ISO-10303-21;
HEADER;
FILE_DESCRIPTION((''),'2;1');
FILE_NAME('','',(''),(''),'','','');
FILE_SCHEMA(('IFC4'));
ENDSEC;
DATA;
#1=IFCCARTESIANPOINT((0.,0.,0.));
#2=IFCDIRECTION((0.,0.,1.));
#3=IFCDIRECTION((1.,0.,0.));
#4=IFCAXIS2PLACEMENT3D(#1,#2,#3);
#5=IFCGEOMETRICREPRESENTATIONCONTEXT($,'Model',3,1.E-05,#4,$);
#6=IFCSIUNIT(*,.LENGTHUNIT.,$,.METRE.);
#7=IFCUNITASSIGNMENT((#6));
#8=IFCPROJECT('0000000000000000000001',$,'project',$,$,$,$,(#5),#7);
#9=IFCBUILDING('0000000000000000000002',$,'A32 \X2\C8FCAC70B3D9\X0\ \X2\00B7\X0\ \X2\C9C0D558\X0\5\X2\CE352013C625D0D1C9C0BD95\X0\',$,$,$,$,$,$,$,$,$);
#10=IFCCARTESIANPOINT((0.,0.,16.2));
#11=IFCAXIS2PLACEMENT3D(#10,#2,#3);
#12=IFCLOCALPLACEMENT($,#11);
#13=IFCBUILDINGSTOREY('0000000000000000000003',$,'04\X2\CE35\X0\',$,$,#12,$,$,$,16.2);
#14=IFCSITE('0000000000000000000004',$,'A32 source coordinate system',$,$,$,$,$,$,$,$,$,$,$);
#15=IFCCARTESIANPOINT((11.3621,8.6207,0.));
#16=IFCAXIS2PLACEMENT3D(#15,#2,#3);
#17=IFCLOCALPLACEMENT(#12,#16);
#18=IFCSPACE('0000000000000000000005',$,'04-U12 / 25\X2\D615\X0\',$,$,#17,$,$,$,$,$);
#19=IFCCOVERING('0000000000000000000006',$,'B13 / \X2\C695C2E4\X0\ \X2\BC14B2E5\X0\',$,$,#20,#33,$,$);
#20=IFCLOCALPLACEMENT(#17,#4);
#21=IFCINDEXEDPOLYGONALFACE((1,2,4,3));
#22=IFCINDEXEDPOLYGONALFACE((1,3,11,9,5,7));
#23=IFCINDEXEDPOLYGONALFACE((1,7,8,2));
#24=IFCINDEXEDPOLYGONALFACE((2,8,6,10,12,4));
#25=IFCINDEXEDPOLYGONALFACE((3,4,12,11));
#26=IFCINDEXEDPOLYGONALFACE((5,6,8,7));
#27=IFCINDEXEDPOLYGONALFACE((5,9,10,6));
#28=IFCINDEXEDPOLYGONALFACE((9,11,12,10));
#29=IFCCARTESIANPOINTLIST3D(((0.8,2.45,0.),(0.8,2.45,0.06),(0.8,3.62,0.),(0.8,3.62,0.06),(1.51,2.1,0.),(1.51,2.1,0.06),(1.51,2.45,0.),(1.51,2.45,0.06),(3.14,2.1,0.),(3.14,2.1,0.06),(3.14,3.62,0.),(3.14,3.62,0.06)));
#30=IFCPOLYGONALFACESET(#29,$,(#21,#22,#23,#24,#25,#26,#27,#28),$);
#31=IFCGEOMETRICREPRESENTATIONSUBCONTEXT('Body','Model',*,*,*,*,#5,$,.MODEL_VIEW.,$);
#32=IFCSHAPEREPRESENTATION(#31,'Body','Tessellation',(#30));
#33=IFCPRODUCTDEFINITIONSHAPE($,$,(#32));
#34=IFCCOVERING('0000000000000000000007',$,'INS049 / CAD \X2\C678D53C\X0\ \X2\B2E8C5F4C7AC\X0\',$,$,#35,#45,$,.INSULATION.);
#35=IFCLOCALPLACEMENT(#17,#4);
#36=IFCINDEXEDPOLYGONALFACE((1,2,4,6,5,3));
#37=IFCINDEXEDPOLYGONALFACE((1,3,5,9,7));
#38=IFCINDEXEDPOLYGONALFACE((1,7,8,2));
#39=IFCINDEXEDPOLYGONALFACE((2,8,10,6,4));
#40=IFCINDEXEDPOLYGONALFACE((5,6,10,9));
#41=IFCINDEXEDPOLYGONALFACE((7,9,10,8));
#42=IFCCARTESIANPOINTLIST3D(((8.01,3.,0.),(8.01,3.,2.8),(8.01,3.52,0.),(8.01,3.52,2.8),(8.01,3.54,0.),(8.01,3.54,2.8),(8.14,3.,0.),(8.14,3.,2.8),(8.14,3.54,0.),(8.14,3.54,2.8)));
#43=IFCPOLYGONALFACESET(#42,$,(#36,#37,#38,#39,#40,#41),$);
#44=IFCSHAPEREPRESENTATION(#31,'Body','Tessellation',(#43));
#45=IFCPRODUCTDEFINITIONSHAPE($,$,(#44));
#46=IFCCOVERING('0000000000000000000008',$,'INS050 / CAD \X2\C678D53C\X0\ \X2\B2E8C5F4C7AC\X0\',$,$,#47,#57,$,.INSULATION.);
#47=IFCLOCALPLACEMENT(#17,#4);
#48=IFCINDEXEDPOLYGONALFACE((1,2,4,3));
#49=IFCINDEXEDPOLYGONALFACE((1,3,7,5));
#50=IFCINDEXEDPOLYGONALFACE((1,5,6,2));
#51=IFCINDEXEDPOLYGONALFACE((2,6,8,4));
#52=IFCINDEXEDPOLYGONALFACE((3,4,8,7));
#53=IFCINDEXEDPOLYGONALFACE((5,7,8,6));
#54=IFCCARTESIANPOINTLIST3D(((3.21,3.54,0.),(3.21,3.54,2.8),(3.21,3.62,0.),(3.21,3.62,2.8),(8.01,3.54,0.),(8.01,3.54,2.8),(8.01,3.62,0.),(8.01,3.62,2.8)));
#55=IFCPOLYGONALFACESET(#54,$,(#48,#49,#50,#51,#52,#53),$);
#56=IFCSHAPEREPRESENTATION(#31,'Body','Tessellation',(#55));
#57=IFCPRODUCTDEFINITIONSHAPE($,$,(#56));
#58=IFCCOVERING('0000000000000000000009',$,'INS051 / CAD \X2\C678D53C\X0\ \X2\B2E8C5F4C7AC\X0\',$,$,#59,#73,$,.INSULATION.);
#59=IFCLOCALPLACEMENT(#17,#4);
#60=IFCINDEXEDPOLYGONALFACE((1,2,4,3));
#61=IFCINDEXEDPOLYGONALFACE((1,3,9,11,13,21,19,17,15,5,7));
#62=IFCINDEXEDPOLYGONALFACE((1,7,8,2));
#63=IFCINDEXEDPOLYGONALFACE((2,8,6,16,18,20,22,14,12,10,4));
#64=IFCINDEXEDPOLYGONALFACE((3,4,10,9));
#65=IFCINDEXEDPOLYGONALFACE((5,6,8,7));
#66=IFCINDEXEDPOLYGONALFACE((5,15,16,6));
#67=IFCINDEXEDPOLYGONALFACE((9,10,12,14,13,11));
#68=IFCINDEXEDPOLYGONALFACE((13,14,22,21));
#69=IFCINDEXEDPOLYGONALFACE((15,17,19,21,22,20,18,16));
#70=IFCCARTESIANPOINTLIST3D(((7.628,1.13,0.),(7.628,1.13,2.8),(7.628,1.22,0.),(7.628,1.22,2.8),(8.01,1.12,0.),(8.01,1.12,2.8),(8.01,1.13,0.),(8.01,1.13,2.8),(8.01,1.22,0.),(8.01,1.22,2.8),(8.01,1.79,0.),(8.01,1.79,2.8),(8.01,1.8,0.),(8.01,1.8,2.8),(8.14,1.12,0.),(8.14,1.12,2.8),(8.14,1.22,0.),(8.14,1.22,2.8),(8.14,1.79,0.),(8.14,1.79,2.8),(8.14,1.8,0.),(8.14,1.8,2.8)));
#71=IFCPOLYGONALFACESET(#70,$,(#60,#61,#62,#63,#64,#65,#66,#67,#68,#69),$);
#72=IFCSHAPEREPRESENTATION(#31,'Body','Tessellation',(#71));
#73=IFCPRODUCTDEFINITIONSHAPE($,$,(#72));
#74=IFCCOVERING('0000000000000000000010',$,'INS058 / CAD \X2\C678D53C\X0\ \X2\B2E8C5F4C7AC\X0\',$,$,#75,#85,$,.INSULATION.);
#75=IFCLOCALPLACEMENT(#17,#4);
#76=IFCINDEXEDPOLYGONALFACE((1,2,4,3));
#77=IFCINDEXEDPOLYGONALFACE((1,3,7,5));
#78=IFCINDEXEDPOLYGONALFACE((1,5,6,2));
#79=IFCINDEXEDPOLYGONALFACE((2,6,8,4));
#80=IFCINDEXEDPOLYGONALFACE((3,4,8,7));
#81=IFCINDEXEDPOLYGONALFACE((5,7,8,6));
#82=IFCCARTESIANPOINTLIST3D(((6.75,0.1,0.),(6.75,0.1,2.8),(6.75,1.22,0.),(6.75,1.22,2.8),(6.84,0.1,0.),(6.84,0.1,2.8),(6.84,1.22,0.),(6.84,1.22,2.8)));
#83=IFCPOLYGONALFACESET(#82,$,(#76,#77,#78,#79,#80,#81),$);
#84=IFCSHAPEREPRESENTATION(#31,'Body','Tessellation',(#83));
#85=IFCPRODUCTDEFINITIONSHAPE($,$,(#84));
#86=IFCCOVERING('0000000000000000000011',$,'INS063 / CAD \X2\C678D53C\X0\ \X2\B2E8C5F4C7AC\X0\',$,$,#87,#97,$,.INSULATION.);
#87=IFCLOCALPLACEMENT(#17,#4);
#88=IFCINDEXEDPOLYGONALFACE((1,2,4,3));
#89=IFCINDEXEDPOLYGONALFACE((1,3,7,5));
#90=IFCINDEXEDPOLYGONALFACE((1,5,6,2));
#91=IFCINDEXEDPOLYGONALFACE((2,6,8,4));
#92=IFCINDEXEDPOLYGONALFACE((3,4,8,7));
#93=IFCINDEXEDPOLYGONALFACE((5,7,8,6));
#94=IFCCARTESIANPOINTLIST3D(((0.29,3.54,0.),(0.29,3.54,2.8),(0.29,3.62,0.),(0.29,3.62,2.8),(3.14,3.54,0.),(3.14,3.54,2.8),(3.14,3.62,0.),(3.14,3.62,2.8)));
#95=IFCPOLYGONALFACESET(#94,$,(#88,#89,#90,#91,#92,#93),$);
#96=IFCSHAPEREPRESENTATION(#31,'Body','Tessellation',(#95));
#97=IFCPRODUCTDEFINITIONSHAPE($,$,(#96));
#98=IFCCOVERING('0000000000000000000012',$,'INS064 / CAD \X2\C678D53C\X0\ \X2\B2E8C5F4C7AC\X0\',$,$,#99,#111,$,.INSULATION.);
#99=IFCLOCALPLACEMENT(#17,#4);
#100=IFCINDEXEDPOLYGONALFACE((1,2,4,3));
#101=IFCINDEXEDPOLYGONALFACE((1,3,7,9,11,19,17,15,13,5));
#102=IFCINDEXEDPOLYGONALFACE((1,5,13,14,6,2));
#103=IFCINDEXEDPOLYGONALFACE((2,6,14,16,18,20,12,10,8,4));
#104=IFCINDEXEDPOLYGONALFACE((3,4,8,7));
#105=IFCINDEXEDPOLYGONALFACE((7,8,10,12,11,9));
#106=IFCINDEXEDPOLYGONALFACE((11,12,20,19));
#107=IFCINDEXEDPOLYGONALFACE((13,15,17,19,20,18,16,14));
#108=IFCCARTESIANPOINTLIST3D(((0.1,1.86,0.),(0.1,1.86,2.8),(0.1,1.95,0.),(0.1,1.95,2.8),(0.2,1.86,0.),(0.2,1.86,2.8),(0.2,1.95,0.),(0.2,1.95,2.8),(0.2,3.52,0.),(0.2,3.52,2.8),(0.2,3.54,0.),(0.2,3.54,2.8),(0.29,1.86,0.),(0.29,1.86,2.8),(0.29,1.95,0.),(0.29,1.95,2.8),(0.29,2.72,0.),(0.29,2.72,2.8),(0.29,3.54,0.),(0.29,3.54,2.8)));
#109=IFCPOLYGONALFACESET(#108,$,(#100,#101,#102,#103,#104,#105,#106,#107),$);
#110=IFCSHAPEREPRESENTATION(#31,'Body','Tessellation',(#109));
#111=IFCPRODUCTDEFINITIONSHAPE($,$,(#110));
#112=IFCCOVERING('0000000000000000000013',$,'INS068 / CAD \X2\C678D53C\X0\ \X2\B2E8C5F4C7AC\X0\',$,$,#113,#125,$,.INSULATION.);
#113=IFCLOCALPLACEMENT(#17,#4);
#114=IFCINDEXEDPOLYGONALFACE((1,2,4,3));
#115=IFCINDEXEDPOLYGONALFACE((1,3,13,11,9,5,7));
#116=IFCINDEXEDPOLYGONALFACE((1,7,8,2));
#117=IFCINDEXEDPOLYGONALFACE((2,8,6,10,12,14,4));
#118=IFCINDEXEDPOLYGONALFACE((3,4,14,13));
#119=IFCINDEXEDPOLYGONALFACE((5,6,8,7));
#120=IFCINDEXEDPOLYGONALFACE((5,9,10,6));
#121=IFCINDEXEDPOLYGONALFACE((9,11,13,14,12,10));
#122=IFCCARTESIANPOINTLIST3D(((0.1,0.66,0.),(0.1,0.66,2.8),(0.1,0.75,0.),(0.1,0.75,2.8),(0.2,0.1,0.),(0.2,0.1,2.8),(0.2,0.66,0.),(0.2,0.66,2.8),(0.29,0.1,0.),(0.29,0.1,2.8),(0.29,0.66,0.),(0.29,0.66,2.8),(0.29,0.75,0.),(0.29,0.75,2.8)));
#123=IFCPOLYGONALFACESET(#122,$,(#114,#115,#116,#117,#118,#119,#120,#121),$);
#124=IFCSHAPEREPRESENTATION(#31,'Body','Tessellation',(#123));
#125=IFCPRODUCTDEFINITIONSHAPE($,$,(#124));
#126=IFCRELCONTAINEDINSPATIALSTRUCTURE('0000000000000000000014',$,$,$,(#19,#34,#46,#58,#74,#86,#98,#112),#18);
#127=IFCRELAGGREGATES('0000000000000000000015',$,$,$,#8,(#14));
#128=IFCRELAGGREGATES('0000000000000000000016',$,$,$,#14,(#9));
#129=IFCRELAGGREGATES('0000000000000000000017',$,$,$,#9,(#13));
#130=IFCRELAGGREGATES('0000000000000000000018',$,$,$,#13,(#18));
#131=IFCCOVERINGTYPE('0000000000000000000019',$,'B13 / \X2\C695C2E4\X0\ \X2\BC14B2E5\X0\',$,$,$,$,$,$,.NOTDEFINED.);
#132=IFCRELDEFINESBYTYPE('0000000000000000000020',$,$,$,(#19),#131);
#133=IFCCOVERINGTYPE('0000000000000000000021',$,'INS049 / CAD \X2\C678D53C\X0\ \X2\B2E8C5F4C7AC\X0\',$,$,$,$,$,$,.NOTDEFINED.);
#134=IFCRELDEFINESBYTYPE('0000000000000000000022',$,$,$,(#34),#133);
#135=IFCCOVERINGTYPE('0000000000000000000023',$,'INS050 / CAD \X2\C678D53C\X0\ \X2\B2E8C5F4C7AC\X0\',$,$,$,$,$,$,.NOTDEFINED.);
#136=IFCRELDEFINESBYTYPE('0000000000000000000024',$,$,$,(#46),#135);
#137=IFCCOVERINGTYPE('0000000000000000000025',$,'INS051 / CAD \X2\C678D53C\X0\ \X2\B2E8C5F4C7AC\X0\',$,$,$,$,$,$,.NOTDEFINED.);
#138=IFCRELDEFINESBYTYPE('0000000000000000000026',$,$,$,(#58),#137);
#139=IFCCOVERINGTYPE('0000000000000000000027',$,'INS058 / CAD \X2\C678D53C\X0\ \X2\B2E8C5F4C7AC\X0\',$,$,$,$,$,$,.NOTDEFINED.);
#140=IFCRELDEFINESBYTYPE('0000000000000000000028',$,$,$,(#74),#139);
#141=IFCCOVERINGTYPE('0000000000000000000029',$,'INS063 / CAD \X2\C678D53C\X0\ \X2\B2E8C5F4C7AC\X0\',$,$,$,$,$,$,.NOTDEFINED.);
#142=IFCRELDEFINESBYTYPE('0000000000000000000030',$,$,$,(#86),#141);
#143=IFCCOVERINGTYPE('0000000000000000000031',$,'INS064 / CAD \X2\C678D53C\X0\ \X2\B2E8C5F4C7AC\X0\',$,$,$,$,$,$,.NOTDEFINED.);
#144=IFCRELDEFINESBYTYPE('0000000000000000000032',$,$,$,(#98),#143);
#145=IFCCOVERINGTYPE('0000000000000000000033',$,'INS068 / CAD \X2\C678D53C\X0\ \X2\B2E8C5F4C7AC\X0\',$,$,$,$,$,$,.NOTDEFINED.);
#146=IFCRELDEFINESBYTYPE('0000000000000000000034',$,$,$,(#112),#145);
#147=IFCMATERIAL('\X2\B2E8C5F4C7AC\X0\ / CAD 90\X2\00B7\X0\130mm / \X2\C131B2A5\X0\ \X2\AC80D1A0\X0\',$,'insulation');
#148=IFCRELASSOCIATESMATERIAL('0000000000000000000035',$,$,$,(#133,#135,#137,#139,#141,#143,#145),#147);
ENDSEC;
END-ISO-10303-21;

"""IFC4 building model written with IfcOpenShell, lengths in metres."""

from ifc_helpers import new_model, si_unit, frame, origin, origin_with_axes, place, context, subcontext, project, spatial, polyline, outline, extrude, source, transform, mapped, material, type_object, type_shapes, element, save


model = new_model("IFC4")

# Units and contexts
model_context = context("Model", 3, precision=1e-05, world=origin_with_axes())
body_context = subcontext(model_context, "Body", "Model", "MODEL_VIEW")
ifc_project = project(units=[si_unit("LENGTHUNIT", "METRE")], contexts=[model_context])

# Site, building, storey
site = spatial("IfcSite", under=ifc_project, Name="A32 source coordinate system")
building = spatial("IfcBuilding", under=site, Name="A32 주거동 · 지하5층–옥탑지붕")
storey_placement = place(None, frame((0.0, 0.0, 16.2), z_axis=(0.0, 0.0, 1.0), x_axis=(1.0, 0.0, 0.0)))
storey = spatial("IfcBuildingStorey", under=building, at=storey_placement, Name="04층", Elevation=16.2)

# Shared definitions
space_1_placement = place(storey_placement, frame((11.3621, 8.6207, 0.0), z_axis=(0.0, 0.0, 1.0), x_axis=(1.0, 0.0, 0.0)))
space_1 = spatial("IfcSpace", under=storey, at=space_1_placement, Name="04-U12 / 25형")

# Coverings
covering_type_1 = type_object("IfcCoveringType", Name="B13 / 욕실 바닥", PredefinedType="NOTDEFINED")
shared_shape_1 = source(origin(), body_context, "Body", "SweptSolid", [
    extrude(outline(polyline([(3.14, 2.1), (1.51, 2.1), (1.51, 2.45), (0.8, 2.45), (0.8, 3.62), (3.14, 3.62), (3.14, 2.1)])), origin(), (0.0, 0.0, 1.0), 0.06),
])
type_shapes(covering_type_1, [shared_shape_1])
covering_1_placement = place(space_1_placement, origin_with_axes())
element("IfcCovering", 1, at=covering_1_placement, inside=space_1, type_object=covering_type_1, Name="B13 / 욕실 바닥", context=body_context, shape_type="MappedRepresentation", body=[
    mapped(shared_shape_1, transform((0.0, 0.0, 0.0), scale=1.0)),
])
ifc_material = material(Name="단열재 / CAD 90·130mm / 성능 검토", Category="insulation")
covering_type_2 = type_object("IfcCoveringType", Name="INS049 / CAD 외피 단열재", PredefinedType="NOTDEFINED", material=ifc_material)
shared_shape_2 = source(origin(), body_context, "Body", "SweptSolid", [
    extrude(outline(polyline([(8.01, 3.54), (8.14, 3.54), (8.14, 3.0), (8.01, 3.0), (8.01, 3.52), (8.01, 3.54)])), origin(), (0.0, 0.0, 1.0), 2.8),
])
type_shapes(covering_type_2, [shared_shape_2])
covering_2_placement = place(space_1_placement, origin_with_axes())
element("IfcCovering", 2, at=covering_2_placement, inside=space_1, type_object=covering_type_2, Name="INS049 / CAD 외피 단열재", PredefinedType="INSULATION", context=body_context, shape_type="MappedRepresentation", body=[
    mapped(shared_shape_2, transform((0.0, 0.0, 0.0), scale=1.0)),
])
covering_type_3 = type_object("IfcCoveringType", Name="INS050 / CAD 외피 단열재", PredefinedType="NOTDEFINED", material=ifc_material)
shared_shape_3 = source(origin(), body_context, "Body", "SweptSolid", [
    extrude(outline(polyline([(8.01, 3.54), (3.21, 3.54), (3.21, 3.62), (8.01, 3.62), (8.01, 3.54)])), origin(), (0.0, 0.0, 1.0), 2.8),
])
type_shapes(covering_type_3, [shared_shape_3])
covering_3_placement = place(space_1_placement, origin_with_axes())
element("IfcCovering", 3, at=covering_3_placement, inside=space_1, type_object=covering_type_3, Name="INS050 / CAD 외피 단열재", PredefinedType="INSULATION", context=body_context, shape_type="MappedRepresentation", body=[
    mapped(shared_shape_3, transform((0.0, 0.0, 0.0), scale=1.0)),
])
covering_type_4 = type_object("IfcCoveringType", Name="INS051 / CAD 외피 단열재", PredefinedType="NOTDEFINED", material=ifc_material)
shared_shape_4 = source(origin(), body_context, "Body", "SweptSolid", [
    extrude(outline(polyline([(8.14, 1.12), (8.01, 1.12), (8.01, 1.13), (7.628, 1.13), (7.628, 1.22), (8.01, 1.22), (8.01, 1.79), (8.01, 1.8), (8.14, 1.8), (8.14, 1.79), (8.14, 1.22), (8.14, 1.12)])), origin(), (0.0, 0.0, 1.0), 2.8),
])
type_shapes(covering_type_4, [shared_shape_4])
covering_4_placement = place(space_1_placement, origin_with_axes())
element("IfcCovering", 4, at=covering_4_placement, inside=space_1, type_object=covering_type_4, Name="INS051 / CAD 외피 단열재", PredefinedType="INSULATION", context=body_context, shape_type="MappedRepresentation", body=[
    mapped(shared_shape_4, transform((0.0, 0.0, 0.0), scale=1.0)),
])
covering_type_5 = type_object("IfcCoveringType", Name="INS058 / CAD 외피 단열재", PredefinedType="NOTDEFINED", material=ifc_material)
shared_shape_5 = source(origin(), body_context, "Body", "SweptSolid", [
    extrude(outline(polyline([(6.75, 0.1), (6.75, 1.22), (6.84, 1.22), (6.84, 0.1), (6.75, 0.1)])), origin(), (0.0, 0.0, 1.0), 2.8),
])
type_shapes(covering_type_5, [shared_shape_5])
covering_5_placement = place(space_1_placement, origin_with_axes())
element("IfcCovering", 5, at=covering_5_placement, inside=space_1, type_object=covering_type_5, Name="INS058 / CAD 외피 단열재", PredefinedType="INSULATION", context=body_context, shape_type="MappedRepresentation", body=[
    mapped(shared_shape_5, transform((0.0, 0.0, 0.0), scale=1.0)),
])
covering_type_6 = type_object("IfcCoveringType", Name="INS063 / CAD 외피 단열재", PredefinedType="NOTDEFINED", material=ifc_material)
shared_shape_6 = source(origin(), body_context, "Body", "SweptSolid", [
    extrude(outline(polyline([(0.29, 3.54), (0.29, 3.62), (3.14, 3.62), (3.14, 3.54), (0.29, 3.54)])), origin(), (0.0, 0.0, 1.0), 2.8),
])
type_shapes(covering_type_6, [shared_shape_6])
covering_6_placement = place(space_1_placement, origin_with_axes())
element("IfcCovering", 6, at=covering_6_placement, inside=space_1, type_object=covering_type_6, Name="INS063 / CAD 외피 단열재", PredefinedType="INSULATION", context=body_context, shape_type="MappedRepresentation", body=[
    mapped(shared_shape_6, transform((0.0, 0.0, 0.0), scale=1.0)),
])
covering_type_7 = type_object("IfcCoveringType", Name="INS064 / CAD 외피 단열재", PredefinedType="NOTDEFINED", material=ifc_material)
shared_shape_7 = source(origin(), body_context, "Body", "SweptSolid", [
    extrude(outline(polyline([(0.1, 1.86), (0.1, 1.95), (0.2, 1.95), (0.2, 3.52), (0.2, 3.54), (0.29, 3.54), (0.29, 2.72), (0.29, 1.95), (0.29, 1.86), (0.2, 1.86), (0.1, 1.86)])), origin(), (0.0, 0.0, 1.0), 2.8),
])
type_shapes(covering_type_7, [shared_shape_7])
covering_7_placement = place(space_1_placement, origin_with_axes())
element("IfcCovering", 7, at=covering_7_placement, inside=space_1, type_object=covering_type_7, Name="INS064 / CAD 외피 단열재", PredefinedType="INSULATION", context=body_context, shape_type="MappedRepresentation", body=[
    mapped(shared_shape_7, transform((0.0, 0.0, 0.0), scale=1.0)),
])
covering_type_8 = type_object("IfcCoveringType", Name="INS068 / CAD 외피 단열재", PredefinedType="NOTDEFINED", material=ifc_material)
shared_shape_8 = source(origin(), body_context, "Body", "SweptSolid", [
    extrude(outline(polyline([(0.2, 0.1), (0.2, 0.66), (0.1, 0.66), (0.1, 0.75), (0.29, 0.75), (0.29, 0.66), (0.29, 0.1), (0.2, 0.1)])), origin(), (0.0, 0.0, 1.0), 2.8),
])
type_shapes(covering_type_8, [shared_shape_8])
covering_8_placement = place(space_1_placement, origin_with_axes())
element("IfcCovering", 8, at=covering_8_placement, inside=space_1, type_object=covering_type_8, Name="INS068 / CAD 외피 단열재", PredefinedType="INSULATION", context=body_context, shape_type="MappedRepresentation", body=[
    mapped(shared_shape_8, transform((0.0, 0.0, 0.0), scale=1.0)),
])

save(model, "model.ifc")
